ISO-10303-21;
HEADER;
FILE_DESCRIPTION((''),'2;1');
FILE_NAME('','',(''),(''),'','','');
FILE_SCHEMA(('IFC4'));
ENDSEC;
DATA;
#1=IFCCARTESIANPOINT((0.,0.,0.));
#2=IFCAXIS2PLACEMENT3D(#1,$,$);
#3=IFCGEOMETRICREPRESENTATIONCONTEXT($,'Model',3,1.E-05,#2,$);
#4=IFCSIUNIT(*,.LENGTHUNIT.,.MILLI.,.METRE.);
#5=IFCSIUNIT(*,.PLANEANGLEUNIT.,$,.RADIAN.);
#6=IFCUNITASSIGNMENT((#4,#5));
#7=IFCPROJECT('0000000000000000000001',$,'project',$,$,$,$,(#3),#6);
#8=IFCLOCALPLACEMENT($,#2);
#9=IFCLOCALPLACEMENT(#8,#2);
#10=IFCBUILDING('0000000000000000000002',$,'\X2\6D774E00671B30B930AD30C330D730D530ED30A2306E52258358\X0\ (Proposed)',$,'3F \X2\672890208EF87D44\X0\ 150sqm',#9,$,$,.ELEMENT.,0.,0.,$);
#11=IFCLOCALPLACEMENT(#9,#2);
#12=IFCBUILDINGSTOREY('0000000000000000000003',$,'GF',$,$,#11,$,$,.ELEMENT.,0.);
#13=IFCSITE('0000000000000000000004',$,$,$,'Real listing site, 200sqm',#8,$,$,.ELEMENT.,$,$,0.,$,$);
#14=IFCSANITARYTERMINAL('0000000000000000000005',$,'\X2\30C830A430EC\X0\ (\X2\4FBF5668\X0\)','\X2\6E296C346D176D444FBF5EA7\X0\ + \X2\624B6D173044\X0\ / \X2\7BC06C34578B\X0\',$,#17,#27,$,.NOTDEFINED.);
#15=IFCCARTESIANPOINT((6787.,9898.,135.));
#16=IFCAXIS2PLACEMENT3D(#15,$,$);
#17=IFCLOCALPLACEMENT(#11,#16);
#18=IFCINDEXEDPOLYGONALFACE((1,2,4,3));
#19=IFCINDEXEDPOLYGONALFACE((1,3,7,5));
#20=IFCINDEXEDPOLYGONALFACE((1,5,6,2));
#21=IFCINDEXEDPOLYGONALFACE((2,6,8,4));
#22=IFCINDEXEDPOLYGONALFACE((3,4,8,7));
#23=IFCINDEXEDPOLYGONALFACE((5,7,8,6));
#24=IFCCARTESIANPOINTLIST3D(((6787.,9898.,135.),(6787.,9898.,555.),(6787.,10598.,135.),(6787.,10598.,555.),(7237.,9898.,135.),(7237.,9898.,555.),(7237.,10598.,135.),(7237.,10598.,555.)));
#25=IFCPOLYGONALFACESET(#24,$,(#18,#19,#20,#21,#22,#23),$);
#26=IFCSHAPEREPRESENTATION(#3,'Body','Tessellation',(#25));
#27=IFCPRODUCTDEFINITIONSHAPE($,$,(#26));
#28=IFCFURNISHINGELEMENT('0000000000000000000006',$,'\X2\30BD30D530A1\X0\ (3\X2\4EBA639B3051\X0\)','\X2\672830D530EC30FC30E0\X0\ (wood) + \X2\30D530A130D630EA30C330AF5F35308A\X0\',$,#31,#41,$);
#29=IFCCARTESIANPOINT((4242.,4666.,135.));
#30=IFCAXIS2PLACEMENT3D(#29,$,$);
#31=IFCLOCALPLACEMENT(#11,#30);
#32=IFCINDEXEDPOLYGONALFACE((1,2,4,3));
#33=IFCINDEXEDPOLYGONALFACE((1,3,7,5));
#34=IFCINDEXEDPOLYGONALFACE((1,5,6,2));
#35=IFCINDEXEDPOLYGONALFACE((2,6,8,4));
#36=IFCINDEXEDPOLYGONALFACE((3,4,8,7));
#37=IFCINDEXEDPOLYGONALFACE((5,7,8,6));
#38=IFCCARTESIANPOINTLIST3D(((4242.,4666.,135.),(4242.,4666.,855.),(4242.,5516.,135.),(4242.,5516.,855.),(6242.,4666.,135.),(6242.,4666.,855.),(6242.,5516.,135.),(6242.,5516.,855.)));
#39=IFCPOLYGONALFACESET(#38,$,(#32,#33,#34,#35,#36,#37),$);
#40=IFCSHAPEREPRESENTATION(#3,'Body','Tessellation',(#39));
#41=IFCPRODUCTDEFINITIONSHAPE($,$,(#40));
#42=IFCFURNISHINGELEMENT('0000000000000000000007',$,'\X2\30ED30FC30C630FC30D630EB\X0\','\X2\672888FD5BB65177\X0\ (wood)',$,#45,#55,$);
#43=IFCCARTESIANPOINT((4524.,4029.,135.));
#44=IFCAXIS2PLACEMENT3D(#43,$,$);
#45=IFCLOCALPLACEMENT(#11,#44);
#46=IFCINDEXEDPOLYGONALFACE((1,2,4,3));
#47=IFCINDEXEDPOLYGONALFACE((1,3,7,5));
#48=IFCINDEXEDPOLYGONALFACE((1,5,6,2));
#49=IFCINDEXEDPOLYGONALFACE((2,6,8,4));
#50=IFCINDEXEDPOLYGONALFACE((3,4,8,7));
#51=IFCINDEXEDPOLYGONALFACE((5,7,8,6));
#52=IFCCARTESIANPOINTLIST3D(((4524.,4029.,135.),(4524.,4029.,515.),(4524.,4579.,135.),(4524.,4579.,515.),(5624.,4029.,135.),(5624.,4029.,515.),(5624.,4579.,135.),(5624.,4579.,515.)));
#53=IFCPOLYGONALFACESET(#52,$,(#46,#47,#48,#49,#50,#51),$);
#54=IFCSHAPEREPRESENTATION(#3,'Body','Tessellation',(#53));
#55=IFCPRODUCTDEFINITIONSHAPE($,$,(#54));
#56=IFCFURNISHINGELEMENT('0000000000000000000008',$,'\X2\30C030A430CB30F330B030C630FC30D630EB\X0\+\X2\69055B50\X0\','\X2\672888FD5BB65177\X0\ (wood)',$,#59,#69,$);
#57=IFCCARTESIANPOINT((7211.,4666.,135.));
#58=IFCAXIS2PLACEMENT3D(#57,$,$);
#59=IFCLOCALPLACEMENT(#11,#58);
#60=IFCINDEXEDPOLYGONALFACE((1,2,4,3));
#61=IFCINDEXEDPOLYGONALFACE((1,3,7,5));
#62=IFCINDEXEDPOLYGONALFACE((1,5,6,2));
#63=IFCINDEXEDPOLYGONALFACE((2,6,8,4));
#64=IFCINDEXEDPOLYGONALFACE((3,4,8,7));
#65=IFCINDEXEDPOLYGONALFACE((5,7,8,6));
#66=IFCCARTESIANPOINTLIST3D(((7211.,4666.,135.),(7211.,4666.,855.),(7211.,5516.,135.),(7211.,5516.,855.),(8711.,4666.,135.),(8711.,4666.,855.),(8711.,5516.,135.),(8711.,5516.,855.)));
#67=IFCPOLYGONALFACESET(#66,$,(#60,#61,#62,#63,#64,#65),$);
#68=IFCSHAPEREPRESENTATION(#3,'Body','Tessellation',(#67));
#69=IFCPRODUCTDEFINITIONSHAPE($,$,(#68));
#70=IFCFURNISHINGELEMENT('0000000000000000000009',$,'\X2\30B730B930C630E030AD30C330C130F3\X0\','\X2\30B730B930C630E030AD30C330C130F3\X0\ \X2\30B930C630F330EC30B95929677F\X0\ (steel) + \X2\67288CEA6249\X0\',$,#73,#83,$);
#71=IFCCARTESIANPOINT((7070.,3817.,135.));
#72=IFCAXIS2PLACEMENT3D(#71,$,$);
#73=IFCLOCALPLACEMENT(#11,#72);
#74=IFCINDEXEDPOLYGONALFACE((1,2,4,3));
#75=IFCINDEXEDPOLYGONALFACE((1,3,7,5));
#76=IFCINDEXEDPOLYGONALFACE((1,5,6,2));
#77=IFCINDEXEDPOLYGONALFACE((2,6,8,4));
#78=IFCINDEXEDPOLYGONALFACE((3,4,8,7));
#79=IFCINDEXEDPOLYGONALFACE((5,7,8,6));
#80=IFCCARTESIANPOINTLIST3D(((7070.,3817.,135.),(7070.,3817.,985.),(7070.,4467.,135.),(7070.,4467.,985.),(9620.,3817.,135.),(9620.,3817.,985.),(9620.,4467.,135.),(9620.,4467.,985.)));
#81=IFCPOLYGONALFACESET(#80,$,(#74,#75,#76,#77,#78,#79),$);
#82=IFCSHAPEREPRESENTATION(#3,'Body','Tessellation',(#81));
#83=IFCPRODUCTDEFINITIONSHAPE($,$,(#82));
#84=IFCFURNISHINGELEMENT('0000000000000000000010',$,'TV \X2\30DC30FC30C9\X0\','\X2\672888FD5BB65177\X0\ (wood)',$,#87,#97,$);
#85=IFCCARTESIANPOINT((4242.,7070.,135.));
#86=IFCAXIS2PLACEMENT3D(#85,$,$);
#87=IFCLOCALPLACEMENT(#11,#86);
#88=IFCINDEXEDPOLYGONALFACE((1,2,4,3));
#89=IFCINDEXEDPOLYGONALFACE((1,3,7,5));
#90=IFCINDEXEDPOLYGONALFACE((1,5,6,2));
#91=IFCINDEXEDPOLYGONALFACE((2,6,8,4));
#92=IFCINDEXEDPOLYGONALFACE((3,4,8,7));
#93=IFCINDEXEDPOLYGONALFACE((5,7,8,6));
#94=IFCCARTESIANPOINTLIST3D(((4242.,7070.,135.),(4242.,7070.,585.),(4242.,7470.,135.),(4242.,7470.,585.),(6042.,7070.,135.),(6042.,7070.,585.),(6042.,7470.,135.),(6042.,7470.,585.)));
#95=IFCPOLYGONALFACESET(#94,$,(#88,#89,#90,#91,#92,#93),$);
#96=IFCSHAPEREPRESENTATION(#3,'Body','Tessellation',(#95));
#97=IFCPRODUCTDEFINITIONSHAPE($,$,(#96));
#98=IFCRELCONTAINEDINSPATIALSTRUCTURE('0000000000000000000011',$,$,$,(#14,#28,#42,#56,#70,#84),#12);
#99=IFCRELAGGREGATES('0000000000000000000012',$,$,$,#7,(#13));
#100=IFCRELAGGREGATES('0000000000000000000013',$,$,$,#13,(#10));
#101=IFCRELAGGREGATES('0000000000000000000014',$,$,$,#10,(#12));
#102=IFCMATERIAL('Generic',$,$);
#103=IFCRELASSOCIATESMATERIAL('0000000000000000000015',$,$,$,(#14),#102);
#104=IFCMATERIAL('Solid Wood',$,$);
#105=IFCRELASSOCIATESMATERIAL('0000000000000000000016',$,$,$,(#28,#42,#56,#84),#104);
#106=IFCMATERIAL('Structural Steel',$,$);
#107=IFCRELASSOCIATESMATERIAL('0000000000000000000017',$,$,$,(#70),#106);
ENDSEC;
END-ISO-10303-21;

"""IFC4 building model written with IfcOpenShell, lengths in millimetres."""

from ifc_helpers import new_model, si_unit, frame, frame_2d, origin, place, context, project, spatial, rectangle, extrude, material, element, save


model = new_model("IFC4")

# Units and contexts
model_context = context("Model", 3, precision=1e-05, world=origin())
ifc_project = project(units=[si_unit("LENGTHUNIT", "METRE", prefix="MILLI"), si_unit("PLANEANGLEUNIT", "RADIAN")], contexts=[model_context])

# Site, building, storey
site_placement = place(None, origin())
site = spatial("IfcSite", under=ifc_project, at=site_placement, ObjectType="Real listing site, 200sqm", CompositionType="ELEMENT", RefElevation=0.0)
building_placement = place(site_placement, origin())
building = spatial("IfcBuilding", under=site, at=building_placement, Name="海一望スキップフロアの別荘 (Proposed)", ObjectType="3F 木造軸組 150sqm", CompositionType="ELEMENT", ElevationOfRefHeight=0.0, ElevationOfTerrain=0.0)
storey_placement = place(building_placement, origin())
storey = spatial("IfcBuildingStorey", under=building, at=storey_placement, Name="GF", CompositionType="ELEMENT", Elevation=0.0)

# Shared definitions
ifc_material_1 = material(Name="Solid Wood")

# Sanitary terminal
ifc_material_2 = material(Name="Generic")
sanitary_terminal_1_placement = place(storey_placement, frame((6787.0, 9898.0, 135.0)))
element("IfcSanitaryTerminal", 1, at=sanitary_terminal_1_placement, inside=storey, material=ifc_material_2, Name="トイレ (便器)", Description="温水洗浄便座 + 手洗い / 節水型", PredefinedType="NOTDEFINED", context=model_context, shape_type="SweptSolid", body=[
    extrude(rectangle(XDim=450.0, YDim=700.0, at=frame_2d((225.0, 350.0))), frame((6787.0, 9898.0, 135.0)), (0.0, 0.0, 1.0), 420.0),
])

# Furnishing elements
furnishing_1_placement = place(storey_placement, frame((4242.0, 4666.0, 135.0)))
element("IfcFurnishingElement", 2, at=furnishing_1_placement, inside=storey, material=ifc_material_1, Name="ソファ (3人掛け)", Description="木フレーム (wood) + ファブリック張り", context=model_context, shape_type="SweptSolid", body=[
    extrude(rectangle(XDim=2000.0, YDim=850.0, at=frame_2d((1000.0, 425.0))), frame((4242.0, 4666.0, 135.0)), (0.0, 0.0, 1.0), 720.0),
])
furnishing_2_placement = place(storey_placement, frame((4524.0, 4029.0, 135.0)))
element("IfcFurnishingElement", 3, at=furnishing_2_placement, inside=storey, material=ifc_material_1, Name="ローテーブル", Description="木製家具 (wood)", context=model_context, shape_type="SweptSolid", body=[
    extrude(rectangle(XDim=1100.0, YDim=550.0, at=frame_2d((550.0, 275.0))), frame((4524.0, 4029.0, 135.0)), (0.0, 0.0, 1.0), 380.0),
])
furnishing_3_placement = place(storey_placement, frame((7211.0, 4666.0, 135.0)))
element("IfcFurnishingElement", 4, at=furnishing_3_placement, inside=storey, material=ifc_material_1, Name="ダイニングテーブル+椅子", Description="木製家具 (wood)", context=model_context, shape_type="SweptSolid", body=[
    extrude(rectangle(XDim=1500.0, YDim=850.0, at=frame_2d((750.0, 425.0))), frame((7211.0, 4666.0, 135.0)), (0.0, 0.0, 1.0), 720.0),
])
ifc_material_3 = material(Name="Structural Steel")
furnishing_4_placement = place(storey_placement, frame((7070.0, 3817.0, 135.0)))
element("IfcFurnishingElement", 5, at=furnishing_4_placement, inside=storey, material=ifc_material_3, Name="システムキッチン", Description="システムキッチン ステンレス天板 (steel) + 木質扉", context=model_context, shape_type="SweptSolid", body=[
    extrude(rectangle(XDim=2550.0, YDim=650.0, at=frame_2d((1275.0, 325.0))), frame((7070.0, 3817.0, 135.0)), (0.0, 0.0, 1.0), 850.0),
])
furnishing_5_placement = place(storey_placement, frame((4242.0, 7070.0, 135.0)))
element("IfcFurnishingElement", 6, at=furnishing_5_placement, inside=storey, material=ifc_material_1, Name="TV ボード", Description="木製家具 (wood)", context=model_context, shape_type="SweptSolid", body=[
    extrude(rectangle(XDim=1800.0, YDim=400.0, at=frame_2d((900.0, 200.0))), frame((4242.0, 7070.0, 135.0)), (0.0, 0.0, 1.0), 450.0),
])

save(model, "model.ifc")
